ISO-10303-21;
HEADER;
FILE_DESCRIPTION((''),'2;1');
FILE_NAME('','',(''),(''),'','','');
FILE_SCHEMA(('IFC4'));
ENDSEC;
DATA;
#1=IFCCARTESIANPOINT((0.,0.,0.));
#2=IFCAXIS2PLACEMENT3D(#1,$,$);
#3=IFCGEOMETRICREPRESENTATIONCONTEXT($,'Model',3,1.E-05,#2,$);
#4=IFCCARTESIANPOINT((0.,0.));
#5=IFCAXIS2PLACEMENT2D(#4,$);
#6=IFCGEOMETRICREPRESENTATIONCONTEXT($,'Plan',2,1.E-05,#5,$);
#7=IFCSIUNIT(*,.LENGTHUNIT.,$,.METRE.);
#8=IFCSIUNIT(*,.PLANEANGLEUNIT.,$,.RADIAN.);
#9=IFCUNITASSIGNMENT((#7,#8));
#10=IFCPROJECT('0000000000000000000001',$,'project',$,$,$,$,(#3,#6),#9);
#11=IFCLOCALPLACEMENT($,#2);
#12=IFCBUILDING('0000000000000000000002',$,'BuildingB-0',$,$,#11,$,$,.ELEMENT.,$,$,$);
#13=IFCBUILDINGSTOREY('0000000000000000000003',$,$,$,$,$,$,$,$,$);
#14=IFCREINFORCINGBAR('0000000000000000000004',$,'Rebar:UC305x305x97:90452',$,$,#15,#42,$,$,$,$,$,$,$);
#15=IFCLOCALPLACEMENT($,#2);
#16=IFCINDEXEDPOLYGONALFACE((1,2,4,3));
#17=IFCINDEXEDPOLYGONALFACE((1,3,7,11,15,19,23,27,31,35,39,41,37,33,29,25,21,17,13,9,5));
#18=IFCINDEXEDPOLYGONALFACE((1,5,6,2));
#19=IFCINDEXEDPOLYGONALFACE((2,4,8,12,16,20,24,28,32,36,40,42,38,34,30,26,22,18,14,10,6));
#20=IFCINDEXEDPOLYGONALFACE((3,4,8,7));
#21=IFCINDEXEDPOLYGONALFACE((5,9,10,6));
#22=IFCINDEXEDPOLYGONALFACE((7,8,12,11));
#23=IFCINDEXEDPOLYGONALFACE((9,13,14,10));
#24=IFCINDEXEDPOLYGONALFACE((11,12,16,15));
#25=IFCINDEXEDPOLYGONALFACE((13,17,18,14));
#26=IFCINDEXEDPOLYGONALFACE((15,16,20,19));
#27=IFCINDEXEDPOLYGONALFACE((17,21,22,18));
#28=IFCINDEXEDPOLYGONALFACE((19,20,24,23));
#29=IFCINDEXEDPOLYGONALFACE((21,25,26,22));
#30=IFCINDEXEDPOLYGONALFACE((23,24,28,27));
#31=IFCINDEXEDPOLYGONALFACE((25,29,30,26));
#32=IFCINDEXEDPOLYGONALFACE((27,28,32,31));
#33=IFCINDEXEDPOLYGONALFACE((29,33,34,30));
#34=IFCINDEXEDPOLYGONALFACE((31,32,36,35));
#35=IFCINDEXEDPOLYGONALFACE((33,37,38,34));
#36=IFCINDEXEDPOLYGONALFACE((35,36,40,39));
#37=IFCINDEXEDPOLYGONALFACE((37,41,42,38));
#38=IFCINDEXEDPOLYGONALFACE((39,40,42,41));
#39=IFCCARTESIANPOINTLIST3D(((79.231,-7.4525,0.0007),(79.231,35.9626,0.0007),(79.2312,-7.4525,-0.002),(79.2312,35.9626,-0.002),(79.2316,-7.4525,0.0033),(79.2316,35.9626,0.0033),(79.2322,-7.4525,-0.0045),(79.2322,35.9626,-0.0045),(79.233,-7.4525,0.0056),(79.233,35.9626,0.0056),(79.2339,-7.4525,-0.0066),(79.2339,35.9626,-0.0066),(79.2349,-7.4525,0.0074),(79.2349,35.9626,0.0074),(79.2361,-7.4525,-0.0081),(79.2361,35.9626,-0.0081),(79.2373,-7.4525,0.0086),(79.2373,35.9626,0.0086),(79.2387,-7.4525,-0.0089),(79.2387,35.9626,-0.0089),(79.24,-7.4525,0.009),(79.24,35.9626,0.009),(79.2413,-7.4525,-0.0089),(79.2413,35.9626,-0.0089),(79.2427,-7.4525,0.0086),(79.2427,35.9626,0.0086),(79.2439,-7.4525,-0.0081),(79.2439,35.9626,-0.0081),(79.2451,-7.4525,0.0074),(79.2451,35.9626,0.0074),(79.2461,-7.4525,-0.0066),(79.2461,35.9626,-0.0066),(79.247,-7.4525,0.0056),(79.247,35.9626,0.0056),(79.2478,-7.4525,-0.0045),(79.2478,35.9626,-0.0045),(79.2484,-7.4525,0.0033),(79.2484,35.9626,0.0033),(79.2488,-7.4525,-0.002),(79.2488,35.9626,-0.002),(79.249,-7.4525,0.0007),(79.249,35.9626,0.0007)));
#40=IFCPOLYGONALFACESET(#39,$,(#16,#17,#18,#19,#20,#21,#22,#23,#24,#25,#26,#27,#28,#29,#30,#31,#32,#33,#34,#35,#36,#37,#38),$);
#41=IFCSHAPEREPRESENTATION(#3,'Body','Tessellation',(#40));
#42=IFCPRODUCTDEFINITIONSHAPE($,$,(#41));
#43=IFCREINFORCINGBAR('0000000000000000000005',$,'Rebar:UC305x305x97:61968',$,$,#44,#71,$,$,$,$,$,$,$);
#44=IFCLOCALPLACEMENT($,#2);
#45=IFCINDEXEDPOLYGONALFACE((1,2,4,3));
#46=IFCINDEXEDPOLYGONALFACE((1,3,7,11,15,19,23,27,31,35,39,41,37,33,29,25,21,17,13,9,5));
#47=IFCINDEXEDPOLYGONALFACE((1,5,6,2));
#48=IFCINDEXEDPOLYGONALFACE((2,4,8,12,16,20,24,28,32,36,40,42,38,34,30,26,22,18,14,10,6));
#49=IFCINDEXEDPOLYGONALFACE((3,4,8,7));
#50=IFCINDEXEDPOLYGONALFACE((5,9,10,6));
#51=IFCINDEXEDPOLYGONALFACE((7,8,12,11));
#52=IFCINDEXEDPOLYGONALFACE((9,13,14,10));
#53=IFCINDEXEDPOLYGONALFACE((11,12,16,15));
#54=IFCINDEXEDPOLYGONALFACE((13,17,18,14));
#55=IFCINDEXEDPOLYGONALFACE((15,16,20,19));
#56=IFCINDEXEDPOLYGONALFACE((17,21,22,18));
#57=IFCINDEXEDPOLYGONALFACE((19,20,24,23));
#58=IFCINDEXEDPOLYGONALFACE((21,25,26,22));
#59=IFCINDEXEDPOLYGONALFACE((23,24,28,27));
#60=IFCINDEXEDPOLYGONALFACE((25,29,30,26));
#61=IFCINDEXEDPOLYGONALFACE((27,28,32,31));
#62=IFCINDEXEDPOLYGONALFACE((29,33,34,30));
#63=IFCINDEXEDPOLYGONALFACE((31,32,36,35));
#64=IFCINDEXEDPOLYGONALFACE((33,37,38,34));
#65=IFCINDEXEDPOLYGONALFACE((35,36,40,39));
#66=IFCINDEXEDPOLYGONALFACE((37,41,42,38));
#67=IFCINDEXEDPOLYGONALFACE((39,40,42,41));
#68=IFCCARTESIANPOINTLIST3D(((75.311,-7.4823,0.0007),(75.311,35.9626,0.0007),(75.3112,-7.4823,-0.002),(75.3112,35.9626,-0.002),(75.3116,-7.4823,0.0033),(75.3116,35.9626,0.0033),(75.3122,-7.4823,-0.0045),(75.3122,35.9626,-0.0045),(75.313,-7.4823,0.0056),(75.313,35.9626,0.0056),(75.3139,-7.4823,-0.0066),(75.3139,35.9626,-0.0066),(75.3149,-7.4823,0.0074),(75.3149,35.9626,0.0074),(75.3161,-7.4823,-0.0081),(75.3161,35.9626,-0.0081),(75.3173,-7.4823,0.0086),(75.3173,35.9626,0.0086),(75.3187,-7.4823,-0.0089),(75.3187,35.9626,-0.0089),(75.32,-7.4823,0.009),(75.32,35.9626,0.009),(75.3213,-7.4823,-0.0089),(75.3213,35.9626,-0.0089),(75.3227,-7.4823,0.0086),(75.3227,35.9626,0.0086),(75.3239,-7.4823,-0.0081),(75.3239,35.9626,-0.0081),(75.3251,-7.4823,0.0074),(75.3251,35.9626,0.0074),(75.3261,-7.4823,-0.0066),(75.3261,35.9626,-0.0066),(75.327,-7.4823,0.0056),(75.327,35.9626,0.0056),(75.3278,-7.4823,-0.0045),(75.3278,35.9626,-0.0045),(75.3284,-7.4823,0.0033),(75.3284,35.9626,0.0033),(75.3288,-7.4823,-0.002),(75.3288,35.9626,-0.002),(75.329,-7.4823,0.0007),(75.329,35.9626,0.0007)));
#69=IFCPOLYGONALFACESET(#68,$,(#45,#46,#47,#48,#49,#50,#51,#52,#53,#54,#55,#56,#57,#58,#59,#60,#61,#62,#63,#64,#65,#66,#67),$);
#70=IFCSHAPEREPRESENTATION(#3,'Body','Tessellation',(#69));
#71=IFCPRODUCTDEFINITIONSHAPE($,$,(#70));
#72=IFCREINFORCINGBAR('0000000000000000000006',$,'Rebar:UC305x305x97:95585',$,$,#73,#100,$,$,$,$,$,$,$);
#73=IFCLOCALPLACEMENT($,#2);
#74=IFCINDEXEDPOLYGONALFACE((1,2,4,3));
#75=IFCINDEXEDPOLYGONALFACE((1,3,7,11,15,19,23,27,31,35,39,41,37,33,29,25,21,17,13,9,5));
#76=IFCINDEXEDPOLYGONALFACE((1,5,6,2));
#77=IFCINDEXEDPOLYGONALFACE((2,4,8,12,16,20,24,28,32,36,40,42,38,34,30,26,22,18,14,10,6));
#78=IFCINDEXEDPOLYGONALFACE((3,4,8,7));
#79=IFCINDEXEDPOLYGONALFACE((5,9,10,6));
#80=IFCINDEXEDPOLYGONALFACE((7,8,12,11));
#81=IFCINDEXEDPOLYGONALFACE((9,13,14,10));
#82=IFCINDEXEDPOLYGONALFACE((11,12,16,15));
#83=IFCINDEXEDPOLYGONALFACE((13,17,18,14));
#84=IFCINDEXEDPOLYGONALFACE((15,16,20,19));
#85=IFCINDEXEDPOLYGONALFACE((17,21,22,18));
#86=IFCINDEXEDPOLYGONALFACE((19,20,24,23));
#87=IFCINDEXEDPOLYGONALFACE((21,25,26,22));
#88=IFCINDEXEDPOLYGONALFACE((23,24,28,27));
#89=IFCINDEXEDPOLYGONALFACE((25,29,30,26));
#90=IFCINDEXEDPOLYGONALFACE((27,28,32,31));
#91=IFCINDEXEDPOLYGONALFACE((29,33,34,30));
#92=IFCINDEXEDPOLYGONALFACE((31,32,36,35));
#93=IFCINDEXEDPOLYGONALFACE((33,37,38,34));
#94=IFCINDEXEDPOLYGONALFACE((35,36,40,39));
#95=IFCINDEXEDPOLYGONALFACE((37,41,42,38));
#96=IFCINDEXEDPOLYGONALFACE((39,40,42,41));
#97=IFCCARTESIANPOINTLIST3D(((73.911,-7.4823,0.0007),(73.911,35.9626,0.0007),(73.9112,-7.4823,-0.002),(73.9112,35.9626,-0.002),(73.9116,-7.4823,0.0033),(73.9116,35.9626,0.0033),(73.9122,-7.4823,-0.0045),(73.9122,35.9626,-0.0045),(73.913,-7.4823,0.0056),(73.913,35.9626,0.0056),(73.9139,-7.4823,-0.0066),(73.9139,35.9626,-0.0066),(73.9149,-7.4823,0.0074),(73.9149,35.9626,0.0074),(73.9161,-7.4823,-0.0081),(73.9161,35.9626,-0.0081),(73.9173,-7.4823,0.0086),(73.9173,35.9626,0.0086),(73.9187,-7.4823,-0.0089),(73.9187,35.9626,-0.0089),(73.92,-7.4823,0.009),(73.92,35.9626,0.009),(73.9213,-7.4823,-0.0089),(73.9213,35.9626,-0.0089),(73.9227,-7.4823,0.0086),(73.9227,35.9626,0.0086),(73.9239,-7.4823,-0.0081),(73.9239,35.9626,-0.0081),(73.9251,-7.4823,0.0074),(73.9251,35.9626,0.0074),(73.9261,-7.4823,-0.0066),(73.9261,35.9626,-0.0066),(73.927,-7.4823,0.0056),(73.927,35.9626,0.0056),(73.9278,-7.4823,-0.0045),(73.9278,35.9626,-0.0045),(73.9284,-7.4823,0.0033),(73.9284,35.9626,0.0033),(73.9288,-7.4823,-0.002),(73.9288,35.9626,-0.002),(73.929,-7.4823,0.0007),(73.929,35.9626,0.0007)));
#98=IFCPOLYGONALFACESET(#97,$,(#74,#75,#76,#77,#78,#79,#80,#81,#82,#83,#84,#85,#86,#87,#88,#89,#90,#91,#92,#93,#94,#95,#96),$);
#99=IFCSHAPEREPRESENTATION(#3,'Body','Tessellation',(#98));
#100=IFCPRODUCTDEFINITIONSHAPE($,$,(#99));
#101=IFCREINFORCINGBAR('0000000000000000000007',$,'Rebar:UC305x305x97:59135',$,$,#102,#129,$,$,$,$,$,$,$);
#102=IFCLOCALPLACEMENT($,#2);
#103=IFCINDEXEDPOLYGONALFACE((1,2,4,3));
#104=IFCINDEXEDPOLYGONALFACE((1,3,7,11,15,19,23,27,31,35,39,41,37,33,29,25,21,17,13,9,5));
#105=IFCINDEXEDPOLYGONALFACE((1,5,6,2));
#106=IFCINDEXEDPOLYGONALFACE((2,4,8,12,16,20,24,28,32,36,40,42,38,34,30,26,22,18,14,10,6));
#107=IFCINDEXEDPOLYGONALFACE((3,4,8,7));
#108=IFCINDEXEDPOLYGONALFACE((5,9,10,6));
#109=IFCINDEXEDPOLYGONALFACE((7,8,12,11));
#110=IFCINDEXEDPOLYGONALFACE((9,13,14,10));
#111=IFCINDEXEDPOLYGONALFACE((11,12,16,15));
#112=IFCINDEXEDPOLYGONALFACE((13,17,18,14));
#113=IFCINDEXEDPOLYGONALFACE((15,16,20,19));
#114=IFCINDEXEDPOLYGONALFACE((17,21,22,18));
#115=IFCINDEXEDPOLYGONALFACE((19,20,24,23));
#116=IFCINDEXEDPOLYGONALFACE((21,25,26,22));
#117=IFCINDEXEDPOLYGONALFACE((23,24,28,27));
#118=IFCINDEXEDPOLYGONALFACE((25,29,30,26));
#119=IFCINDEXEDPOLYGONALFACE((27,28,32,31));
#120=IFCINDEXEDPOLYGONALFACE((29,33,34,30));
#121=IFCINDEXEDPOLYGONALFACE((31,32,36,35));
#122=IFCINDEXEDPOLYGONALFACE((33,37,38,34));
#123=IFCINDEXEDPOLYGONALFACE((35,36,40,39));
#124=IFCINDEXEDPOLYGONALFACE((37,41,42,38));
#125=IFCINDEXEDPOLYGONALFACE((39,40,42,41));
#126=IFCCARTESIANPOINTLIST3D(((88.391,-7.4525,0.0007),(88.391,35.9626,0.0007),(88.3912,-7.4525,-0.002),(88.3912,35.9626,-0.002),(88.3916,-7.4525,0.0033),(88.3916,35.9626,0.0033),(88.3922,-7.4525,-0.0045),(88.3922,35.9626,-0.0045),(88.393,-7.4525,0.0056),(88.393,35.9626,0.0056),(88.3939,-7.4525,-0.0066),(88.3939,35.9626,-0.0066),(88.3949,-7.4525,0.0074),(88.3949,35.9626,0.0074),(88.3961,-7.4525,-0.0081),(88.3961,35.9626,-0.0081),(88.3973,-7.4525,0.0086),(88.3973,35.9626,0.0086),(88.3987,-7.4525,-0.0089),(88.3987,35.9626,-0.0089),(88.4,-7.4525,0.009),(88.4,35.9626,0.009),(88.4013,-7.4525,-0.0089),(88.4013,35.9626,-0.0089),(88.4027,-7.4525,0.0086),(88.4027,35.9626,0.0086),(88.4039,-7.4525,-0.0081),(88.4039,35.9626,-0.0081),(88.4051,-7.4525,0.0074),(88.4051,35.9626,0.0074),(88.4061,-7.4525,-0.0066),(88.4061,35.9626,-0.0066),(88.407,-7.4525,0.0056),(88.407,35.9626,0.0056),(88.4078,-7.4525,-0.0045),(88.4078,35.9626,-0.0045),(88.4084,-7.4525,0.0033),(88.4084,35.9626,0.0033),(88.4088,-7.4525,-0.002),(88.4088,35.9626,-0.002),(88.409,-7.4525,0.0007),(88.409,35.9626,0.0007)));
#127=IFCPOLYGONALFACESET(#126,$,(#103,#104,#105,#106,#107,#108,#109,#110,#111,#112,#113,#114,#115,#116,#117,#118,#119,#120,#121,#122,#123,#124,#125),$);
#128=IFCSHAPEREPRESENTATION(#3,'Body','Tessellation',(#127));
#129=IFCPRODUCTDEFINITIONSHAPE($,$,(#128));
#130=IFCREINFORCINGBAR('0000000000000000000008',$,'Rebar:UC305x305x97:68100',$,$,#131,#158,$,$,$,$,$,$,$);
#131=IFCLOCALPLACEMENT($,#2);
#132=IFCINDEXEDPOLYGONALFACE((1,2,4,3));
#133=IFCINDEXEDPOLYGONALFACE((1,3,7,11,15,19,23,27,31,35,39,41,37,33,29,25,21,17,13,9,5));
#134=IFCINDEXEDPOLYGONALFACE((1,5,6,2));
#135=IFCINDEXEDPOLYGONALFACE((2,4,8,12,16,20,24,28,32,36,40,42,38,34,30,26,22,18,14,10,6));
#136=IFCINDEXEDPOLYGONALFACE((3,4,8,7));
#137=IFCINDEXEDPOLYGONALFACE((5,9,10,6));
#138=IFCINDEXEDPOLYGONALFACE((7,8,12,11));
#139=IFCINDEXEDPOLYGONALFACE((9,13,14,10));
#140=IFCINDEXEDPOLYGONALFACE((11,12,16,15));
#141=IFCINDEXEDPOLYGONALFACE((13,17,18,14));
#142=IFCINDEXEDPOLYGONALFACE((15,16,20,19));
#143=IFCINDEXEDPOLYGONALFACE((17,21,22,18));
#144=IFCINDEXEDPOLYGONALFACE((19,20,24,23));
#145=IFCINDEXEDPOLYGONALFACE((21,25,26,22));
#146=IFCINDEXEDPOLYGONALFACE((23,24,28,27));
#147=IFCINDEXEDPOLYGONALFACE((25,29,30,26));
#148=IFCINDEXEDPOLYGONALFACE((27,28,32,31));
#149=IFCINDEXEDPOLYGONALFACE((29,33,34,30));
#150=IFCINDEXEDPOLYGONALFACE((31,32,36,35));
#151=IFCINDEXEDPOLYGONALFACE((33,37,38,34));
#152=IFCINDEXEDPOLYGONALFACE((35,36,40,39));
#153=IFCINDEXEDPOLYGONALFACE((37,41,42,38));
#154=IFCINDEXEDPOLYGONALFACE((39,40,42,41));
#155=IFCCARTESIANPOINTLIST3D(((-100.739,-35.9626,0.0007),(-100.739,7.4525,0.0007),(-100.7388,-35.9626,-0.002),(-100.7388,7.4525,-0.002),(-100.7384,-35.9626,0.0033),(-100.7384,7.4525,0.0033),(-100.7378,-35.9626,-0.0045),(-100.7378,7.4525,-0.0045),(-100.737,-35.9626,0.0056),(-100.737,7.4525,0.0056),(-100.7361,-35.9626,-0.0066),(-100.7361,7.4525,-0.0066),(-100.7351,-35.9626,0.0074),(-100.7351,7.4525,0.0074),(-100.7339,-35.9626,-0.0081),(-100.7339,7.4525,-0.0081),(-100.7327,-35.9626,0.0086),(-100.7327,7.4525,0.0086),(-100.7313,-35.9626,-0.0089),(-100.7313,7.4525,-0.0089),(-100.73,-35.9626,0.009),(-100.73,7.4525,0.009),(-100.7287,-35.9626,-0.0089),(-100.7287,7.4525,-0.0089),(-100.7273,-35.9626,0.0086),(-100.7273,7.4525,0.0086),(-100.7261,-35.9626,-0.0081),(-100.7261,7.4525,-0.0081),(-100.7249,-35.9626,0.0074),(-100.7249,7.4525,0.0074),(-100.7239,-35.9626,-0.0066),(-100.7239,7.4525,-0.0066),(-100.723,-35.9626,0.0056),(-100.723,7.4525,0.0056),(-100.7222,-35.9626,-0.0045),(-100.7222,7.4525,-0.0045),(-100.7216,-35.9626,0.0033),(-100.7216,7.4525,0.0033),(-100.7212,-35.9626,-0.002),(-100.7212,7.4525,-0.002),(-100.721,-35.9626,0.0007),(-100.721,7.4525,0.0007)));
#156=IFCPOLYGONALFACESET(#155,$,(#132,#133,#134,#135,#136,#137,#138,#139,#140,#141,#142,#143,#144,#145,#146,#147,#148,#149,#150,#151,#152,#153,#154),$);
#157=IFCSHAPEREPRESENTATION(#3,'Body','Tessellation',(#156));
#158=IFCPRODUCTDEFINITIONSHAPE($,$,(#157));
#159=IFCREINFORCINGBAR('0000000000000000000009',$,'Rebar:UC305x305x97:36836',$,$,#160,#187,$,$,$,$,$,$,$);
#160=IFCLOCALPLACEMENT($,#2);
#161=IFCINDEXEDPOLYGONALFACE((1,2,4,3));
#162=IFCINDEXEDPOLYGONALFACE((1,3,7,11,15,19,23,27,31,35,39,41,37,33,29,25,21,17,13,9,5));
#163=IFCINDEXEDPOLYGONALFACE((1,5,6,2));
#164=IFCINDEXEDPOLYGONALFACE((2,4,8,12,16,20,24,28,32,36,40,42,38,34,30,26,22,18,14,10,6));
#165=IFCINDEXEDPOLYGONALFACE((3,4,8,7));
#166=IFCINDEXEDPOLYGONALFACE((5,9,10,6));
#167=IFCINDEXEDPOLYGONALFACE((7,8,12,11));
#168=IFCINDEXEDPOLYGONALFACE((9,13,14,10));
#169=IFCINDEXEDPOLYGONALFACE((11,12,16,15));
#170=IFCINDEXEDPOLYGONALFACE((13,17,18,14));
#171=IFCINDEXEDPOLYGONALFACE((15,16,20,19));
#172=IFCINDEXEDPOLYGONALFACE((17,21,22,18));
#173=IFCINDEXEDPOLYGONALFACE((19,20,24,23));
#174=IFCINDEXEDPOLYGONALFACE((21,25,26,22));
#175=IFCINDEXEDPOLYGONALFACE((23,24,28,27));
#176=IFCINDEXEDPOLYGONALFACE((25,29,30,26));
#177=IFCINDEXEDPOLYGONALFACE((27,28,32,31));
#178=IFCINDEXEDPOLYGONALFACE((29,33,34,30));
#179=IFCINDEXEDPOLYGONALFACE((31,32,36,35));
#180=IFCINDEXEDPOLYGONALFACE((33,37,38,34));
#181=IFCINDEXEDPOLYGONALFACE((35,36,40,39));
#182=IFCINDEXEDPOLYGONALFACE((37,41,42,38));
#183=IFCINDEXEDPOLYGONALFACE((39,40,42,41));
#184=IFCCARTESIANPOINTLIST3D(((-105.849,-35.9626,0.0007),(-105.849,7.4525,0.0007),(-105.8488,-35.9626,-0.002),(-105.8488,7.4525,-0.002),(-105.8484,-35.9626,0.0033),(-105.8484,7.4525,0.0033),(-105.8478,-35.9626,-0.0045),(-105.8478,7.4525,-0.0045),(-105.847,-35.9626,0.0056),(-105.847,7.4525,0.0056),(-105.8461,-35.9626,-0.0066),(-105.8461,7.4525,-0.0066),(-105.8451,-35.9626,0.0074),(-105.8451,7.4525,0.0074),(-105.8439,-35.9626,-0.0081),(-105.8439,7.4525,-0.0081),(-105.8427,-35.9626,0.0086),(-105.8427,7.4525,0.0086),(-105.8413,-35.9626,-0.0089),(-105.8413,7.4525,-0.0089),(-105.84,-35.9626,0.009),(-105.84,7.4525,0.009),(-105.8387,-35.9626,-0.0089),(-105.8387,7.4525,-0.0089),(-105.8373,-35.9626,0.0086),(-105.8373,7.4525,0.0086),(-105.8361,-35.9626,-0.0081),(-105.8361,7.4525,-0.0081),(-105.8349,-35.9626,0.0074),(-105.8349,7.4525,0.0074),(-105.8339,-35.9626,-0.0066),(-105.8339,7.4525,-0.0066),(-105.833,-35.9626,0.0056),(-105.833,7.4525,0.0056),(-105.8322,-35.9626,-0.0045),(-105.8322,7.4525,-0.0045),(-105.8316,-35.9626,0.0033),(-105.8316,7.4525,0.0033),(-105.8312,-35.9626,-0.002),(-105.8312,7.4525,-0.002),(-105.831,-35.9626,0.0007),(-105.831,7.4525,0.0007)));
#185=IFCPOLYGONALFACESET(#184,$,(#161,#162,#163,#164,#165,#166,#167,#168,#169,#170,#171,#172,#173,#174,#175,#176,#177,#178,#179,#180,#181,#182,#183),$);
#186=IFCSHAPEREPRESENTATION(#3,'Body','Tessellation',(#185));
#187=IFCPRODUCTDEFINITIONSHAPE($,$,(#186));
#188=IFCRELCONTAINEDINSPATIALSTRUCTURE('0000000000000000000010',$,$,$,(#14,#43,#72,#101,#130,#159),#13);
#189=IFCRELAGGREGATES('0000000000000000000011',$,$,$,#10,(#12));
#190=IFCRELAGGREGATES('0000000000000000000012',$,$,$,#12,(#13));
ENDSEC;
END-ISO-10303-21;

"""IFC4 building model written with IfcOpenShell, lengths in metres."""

from ifc_helpers import new_model, entity, si_unit, origin, origin_2d, place, context, project, spatial, element, save


model = new_model("IFC4")

# Units and contexts
model_context = context("Model", 3, precision=1e-05, world=origin())
plan_context = context("Plan", 2, precision=1e-05, world=origin_2d())
ifc_project = project(units=[si_unit("LENGTHUNIT", "METRE"), si_unit("PLANEANGLEUNIT", "RADIAN")], contexts=[model_context, plan_context])

# Building, storey
building_placement = place(None, origin())
building = spatial("IfcBuilding", under=ifc_project, at=building_placement, Name="BuildingB-0", CompositionType="ELEMENT")
storey = spatial("IfcBuildingStorey", under=building)

# Reinforcing bars
element("IfcReinforcingBar", 1, inside=storey, Name="Rebar:UC305x305x97:90452", context=model_context, shape_type="SweptSolid", body=[
    entity("IfcSurfaceCurveSweptAreaSolid", entity("IfcCircleProfileDef", "AREA", None, None, 0.009), None, entity("IfcPolyline", [entity("IfcCartesianPoint", [79.24, 35.9626, 0.0]), entity("IfcCartesianPoint", [79.24, -7.4525, 0.0])]), None, None, entity("IfcPlane", entity("IfcAxis2Placement3D", entity("IfcCartesianPoint", [79.24, 35.9626, 0.0]), entity("IfcDirection", [0.0, 0.0, 1.0]), entity("IfcDirection", [1.0, 0.0, 0.0])))),
])
element("IfcReinforcingBar", 2, inside=storey, Name="Rebar:UC305x305x97:61968", context=model_context, shape_type="SweptSolid", body=[
    entity("IfcSurfaceCurveSweptAreaSolid", entity("IfcCircleProfileDef", "AREA", None, None, 0.009), None, entity("IfcPolyline", [entity("IfcCartesianPoint", [75.32, 35.9626, 0.0]), entity("IfcCartesianPoint", [75.32, -7.4823, 0.0])]), None, None, entity("IfcPlane", entity("IfcAxis2Placement3D", entity("IfcCartesianPoint", [75.32, 35.9626, 0.0]), entity("IfcDirection", [0.0, 0.0, 1.0]), entity("IfcDirection", [1.0, 0.0, 0.0])))),
])
element("IfcReinforcingBar", 3, inside=storey, Name="Rebar:UC305x305x97:95585", context=model_context, shape_type="SweptSolid", body=[
    entity("IfcSurfaceCurveSweptAreaSolid", entity("IfcCircleProfileDef", "AREA", None, None, 0.009), None, entity("IfcPolyline", [entity("IfcCartesianPoint", [73.92, 35.9626, 0.0]), entity("IfcCartesianPoint", [73.92, -7.4823, 0.0])]), None, None, entity("IfcPlane", entity("IfcAxis2Placement3D", entity("IfcCartesianPoint", [73.92, 35.9626, 0.0]), entity("IfcDirection", [0.0, 0.0, 1.0]), entity("IfcDirection", [1.0, 0.0, 0.0])))),
])
element("IfcReinforcingBar", 4, inside=storey, Name="Rebar:UC305x305x97:59135", context=model_context, shape_type="SweptSolid", body=[
    entity("IfcSurfaceCurveSweptAreaSolid", entity("IfcCircleProfileDef", "AREA", None, None, 0.009), None, entity("IfcPolyline", [entity("IfcCartesianPoint", [88.4, 35.9626, 0.0]), entity("IfcCartesianPoint", [88.4, -7.4525, 0.0])]), None, None, entity("IfcPlane", entity("IfcAxis2Placement3D", entity("IfcCartesianPoint", [88.4, 35.9626, 0.0]), entity("IfcDirection", [0.0, 0.0, 1.0]), entity("IfcDirection", [1.0, 0.0, 0.0])))),
])
element("IfcReinforcingBar", 5, inside=storey, Name="Rebar:UC305x305x97:68100", context=model_context, shape_type="SweptSolid", body=[
    entity("IfcSurfaceCurveSweptAreaSolid", entity("IfcCircleProfileDef", "AREA", None, None, 0.009), None, entity("IfcPolyline", [entity("IfcCartesianPoint", [100.73, 35.9626, 0.0]), entity("IfcCartesianPoint", [100.73, -7.4525, 0.0])]), None, None, entity("IfcPlane", entity("IfcAxis2Placement3D", entity("IfcCartesianPoint", [100.73, 35.9626, 0.0]), entity("IfcDirection", [0.0, 0.0, 1.0]), entity("IfcDirection", [1.0, 0.0, 0.0])))),
])
element("IfcReinforcingBar", 6, inside=storey, Name="Rebar:UC305x305x97:36836", context=model_context, shape_type="SweptSolid", body=[
    entity("IfcSurfaceCurveSweptAreaSolid", entity("IfcCircleProfileDef", "AREA", None, None, 0.009), None, entity("IfcPolyline", [entity("IfcCartesianPoint", [105.84, 35.9626, 0.0]), entity("IfcCartesianPoint", [105.84, -7.4525, 0.0])]), None, None, entity("IfcPlane", entity("IfcAxis2Placement3D", entity("IfcCartesianPoint", [105.84, 35.9626, 0.0]), entity("IfcDirection", [0.0, 0.0, 1.0]), entity("IfcDirection", [1.0, 0.0, 0.0])))),
])

save(model, "model.ifc")
